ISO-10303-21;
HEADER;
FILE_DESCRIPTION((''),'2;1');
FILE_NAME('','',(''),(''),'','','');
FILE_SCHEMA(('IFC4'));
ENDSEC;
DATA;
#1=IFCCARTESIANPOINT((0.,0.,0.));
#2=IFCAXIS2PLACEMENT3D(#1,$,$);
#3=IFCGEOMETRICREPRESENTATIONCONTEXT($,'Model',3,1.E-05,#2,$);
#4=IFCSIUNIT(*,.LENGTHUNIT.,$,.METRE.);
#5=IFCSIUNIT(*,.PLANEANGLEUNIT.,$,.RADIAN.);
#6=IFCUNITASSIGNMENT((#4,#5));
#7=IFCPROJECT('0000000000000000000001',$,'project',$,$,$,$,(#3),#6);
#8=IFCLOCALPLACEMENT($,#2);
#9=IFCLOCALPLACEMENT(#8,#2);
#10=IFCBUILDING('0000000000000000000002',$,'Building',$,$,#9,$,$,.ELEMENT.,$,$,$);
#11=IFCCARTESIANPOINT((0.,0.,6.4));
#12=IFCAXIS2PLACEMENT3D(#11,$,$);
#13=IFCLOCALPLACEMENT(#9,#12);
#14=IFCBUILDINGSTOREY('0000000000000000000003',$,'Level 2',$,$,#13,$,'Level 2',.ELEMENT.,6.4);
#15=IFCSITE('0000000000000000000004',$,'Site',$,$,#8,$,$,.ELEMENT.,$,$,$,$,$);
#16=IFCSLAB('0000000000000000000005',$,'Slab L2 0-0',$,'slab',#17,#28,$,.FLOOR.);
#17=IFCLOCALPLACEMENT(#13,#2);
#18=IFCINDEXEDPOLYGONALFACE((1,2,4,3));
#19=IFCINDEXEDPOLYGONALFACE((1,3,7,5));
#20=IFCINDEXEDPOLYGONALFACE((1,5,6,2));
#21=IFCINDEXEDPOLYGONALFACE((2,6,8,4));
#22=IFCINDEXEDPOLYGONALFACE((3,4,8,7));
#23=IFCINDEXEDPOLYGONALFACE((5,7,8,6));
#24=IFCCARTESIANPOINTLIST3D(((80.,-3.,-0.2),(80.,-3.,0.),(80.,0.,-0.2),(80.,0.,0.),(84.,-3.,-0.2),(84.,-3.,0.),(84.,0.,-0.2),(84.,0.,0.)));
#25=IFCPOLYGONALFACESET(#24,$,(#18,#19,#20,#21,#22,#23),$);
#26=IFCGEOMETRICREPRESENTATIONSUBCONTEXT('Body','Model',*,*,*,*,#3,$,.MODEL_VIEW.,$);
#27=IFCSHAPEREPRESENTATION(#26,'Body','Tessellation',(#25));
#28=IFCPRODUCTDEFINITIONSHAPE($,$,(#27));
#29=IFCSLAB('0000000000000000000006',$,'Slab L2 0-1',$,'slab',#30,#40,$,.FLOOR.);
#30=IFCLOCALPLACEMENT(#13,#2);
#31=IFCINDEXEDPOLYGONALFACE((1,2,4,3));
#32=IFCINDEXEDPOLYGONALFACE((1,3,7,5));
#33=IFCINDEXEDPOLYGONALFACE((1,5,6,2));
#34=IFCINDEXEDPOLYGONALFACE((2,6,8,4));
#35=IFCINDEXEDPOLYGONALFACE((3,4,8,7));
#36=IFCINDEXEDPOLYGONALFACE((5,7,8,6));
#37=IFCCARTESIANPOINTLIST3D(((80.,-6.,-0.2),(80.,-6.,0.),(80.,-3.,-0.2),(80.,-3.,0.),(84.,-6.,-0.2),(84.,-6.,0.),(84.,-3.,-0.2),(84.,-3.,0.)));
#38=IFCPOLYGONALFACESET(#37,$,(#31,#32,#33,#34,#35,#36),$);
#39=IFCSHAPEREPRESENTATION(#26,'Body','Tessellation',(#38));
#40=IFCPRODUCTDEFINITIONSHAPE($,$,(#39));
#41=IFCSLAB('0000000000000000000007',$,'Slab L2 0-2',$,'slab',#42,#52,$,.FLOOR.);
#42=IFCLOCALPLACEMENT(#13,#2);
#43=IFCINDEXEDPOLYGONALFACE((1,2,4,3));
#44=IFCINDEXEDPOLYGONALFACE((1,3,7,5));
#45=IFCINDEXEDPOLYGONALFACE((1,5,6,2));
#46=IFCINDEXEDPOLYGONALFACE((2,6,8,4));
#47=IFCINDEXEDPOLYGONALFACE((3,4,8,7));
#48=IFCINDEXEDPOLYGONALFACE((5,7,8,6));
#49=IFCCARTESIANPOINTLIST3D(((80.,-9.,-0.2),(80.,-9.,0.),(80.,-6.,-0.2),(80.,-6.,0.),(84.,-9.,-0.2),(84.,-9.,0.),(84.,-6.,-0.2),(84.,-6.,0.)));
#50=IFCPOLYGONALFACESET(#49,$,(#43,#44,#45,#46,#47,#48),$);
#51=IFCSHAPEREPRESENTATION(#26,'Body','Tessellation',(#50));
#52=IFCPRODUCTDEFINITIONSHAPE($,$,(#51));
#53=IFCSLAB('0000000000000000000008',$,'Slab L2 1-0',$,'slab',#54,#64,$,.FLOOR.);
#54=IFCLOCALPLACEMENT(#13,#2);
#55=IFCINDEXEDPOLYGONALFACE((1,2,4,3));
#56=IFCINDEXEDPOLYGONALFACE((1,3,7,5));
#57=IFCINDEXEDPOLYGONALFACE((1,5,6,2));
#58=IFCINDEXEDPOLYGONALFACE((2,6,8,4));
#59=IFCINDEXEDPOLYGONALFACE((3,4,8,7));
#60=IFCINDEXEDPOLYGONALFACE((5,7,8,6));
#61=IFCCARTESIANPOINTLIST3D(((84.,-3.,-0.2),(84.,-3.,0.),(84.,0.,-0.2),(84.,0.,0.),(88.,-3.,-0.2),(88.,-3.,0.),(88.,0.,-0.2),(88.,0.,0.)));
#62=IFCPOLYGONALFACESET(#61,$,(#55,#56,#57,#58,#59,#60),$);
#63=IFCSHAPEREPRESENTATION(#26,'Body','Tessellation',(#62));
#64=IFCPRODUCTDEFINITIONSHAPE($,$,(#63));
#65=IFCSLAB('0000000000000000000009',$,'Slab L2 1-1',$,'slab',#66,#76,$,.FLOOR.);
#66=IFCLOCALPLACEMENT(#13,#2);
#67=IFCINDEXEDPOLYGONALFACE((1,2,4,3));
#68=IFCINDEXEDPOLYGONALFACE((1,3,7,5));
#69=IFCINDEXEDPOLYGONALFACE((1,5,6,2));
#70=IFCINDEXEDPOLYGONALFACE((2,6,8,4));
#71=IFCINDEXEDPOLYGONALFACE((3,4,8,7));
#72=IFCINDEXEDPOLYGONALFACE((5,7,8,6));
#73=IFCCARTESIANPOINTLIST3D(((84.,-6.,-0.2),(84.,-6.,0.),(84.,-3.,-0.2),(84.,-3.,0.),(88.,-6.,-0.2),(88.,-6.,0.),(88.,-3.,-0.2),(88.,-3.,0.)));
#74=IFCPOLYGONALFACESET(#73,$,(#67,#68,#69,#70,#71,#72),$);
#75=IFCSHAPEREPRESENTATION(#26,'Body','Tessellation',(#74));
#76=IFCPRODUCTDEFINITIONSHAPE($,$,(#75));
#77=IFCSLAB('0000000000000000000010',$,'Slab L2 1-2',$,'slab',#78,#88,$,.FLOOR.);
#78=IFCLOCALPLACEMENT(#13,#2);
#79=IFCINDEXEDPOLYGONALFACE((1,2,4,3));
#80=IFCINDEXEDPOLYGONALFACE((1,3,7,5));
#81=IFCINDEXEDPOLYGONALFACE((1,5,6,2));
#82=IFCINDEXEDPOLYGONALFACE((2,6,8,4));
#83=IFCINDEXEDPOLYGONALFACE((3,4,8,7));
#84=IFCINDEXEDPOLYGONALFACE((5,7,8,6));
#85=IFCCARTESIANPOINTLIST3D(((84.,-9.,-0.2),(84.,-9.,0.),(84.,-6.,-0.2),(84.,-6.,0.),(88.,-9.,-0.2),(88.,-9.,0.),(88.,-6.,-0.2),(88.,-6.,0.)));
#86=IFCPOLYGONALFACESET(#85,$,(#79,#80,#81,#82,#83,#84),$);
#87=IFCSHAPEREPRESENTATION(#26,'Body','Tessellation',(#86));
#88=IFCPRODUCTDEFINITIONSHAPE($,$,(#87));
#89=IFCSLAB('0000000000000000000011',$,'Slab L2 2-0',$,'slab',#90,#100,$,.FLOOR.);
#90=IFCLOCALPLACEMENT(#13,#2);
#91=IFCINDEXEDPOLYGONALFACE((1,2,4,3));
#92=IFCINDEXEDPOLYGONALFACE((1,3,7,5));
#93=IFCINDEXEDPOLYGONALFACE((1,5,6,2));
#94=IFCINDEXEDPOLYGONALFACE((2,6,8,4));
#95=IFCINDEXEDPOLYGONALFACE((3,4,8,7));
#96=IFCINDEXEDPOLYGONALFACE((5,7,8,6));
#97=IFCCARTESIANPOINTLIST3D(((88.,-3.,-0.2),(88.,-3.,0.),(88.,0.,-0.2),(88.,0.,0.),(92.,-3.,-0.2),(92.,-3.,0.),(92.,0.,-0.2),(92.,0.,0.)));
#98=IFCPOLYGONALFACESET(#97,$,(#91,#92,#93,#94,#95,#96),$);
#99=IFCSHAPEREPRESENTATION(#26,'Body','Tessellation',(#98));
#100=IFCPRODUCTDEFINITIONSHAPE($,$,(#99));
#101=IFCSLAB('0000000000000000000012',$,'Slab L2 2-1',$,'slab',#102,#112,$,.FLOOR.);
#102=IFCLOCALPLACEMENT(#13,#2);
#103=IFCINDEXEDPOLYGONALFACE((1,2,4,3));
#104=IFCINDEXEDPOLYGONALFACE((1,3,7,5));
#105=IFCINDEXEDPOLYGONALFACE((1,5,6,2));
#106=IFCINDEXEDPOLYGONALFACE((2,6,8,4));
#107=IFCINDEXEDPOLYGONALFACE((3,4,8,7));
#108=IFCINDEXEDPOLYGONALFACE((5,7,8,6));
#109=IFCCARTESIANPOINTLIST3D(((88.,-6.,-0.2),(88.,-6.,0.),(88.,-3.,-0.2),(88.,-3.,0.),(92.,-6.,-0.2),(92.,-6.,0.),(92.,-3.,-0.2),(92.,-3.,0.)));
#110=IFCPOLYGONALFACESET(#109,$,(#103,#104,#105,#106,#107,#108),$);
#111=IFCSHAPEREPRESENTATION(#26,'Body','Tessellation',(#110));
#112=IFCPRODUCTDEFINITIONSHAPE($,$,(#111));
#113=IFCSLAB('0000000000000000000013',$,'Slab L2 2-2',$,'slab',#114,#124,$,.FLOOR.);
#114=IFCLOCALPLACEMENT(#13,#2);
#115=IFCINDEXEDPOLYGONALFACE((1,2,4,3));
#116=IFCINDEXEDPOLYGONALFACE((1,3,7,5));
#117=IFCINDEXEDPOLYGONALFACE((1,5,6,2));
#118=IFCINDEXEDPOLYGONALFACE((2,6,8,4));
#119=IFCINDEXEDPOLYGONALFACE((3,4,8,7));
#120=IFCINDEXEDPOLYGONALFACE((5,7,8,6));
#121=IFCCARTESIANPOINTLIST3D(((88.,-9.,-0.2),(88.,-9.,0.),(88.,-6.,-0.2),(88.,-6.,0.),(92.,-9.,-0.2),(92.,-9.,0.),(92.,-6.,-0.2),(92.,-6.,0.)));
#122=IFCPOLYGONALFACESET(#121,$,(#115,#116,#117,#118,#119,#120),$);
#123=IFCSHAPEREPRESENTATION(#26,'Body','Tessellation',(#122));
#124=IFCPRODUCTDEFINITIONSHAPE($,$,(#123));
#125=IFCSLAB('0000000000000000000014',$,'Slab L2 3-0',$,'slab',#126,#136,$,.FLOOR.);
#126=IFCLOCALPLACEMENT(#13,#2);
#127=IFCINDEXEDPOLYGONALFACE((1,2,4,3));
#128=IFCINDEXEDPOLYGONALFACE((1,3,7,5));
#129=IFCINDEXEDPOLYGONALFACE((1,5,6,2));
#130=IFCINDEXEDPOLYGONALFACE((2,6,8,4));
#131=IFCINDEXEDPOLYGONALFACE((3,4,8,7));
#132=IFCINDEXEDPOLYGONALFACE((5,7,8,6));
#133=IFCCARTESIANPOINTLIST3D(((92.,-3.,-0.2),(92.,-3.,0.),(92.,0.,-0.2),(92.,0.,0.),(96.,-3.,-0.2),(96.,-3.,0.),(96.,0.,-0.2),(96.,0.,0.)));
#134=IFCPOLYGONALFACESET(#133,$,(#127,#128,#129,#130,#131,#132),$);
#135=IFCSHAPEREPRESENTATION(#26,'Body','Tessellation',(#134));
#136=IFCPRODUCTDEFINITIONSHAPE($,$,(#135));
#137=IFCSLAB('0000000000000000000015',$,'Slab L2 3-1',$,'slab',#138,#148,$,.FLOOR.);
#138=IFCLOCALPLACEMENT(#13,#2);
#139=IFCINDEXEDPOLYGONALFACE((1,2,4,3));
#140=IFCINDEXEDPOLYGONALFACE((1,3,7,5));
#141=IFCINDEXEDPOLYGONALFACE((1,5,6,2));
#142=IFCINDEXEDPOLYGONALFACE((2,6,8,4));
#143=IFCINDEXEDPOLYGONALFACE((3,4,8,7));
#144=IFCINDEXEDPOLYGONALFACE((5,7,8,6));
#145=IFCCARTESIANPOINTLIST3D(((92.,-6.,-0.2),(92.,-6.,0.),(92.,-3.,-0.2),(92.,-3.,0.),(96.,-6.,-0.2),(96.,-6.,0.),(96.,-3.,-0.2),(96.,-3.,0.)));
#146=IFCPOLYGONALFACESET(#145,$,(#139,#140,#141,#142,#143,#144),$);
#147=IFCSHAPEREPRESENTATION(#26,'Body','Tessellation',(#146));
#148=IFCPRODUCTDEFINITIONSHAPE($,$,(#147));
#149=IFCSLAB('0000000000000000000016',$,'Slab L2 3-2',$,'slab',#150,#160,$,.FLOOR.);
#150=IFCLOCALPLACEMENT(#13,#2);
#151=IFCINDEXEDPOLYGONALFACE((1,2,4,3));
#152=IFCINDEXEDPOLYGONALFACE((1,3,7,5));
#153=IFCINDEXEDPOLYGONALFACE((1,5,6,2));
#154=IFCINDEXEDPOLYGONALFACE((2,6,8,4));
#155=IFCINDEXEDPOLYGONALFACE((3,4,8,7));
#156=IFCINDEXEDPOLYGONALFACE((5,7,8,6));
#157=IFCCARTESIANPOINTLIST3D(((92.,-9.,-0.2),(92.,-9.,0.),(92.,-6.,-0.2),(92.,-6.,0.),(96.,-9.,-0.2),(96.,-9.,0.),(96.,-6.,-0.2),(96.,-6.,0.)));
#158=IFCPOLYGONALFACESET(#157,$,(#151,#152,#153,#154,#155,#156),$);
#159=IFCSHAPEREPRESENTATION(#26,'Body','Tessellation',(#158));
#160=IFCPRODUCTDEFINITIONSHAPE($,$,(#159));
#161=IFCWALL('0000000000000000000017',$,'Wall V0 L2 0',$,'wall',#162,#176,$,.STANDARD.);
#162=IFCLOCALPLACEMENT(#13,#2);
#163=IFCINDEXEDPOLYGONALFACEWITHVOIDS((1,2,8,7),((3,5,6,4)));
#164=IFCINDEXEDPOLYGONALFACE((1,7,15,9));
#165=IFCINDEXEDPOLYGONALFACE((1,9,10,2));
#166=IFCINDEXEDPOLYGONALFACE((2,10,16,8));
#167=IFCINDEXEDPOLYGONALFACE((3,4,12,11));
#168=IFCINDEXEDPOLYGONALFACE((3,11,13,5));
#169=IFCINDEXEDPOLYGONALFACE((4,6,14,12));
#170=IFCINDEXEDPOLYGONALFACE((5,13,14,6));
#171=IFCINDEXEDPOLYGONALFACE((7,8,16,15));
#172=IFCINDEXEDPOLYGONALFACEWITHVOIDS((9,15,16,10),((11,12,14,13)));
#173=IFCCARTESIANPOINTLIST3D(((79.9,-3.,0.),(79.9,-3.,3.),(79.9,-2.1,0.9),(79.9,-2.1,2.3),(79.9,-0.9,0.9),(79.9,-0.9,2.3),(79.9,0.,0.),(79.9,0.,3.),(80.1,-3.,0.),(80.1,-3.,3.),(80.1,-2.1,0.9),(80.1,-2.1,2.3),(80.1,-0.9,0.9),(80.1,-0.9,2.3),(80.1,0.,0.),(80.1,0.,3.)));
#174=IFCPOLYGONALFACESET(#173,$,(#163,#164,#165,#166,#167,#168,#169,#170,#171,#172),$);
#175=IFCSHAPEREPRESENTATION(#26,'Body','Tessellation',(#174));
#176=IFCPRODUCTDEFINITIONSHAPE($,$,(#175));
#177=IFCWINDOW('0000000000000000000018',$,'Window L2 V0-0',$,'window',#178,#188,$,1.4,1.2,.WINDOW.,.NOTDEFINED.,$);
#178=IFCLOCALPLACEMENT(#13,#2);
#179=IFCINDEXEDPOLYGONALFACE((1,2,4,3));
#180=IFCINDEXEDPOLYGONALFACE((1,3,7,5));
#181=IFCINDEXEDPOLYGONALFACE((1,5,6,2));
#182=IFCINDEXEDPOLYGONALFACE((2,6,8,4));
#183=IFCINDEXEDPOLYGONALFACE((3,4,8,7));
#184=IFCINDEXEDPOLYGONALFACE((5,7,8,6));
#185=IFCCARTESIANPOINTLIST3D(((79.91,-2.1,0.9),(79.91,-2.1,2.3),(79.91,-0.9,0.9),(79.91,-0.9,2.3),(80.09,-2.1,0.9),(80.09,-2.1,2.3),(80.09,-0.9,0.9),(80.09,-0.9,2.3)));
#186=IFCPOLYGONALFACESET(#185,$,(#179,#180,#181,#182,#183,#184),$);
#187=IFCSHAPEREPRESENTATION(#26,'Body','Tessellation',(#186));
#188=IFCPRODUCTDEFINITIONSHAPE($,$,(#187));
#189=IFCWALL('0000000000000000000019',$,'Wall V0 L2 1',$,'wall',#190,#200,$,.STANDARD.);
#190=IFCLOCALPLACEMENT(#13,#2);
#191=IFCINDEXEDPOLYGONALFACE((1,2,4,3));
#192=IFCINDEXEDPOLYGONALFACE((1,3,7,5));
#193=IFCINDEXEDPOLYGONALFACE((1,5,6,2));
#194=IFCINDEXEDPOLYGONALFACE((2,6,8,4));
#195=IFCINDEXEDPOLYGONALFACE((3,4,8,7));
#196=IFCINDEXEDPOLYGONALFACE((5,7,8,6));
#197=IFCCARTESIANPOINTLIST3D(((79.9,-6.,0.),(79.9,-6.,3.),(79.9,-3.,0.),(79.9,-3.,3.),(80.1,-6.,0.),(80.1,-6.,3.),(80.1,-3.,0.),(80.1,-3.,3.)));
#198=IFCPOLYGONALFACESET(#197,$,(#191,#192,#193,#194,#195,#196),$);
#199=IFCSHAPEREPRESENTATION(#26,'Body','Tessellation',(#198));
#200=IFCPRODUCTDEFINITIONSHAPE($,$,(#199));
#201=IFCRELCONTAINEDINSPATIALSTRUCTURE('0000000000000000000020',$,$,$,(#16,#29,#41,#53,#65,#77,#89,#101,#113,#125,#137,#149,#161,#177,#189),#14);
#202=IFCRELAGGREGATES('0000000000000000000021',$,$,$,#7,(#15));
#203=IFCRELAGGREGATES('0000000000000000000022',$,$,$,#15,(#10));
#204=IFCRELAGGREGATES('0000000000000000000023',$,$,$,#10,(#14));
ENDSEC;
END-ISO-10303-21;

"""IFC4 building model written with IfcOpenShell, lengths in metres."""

from ifc_helpers import new_model, si_unit, frame, frame_2d, origin, origin_2d, place, context, subcontext, project, spatial, polyline, rectangle, outline, extrude, element, fill, save


model = new_model("IFC4")

# Units and contexts
model_context = context("Model", 3, precision=1e-05, world=origin())
body_context = subcontext(model_context, "Body", "Model", "MODEL_VIEW")
ifc_project = project(units=[si_unit("LENGTHUNIT", "METRE"), si_unit("PLANEANGLEUNIT", "RADIAN")], contexts=[model_context])

# Site, building, storey
site_placement = place(None, origin())
site = spatial("IfcSite", under=ifc_project, at=site_placement, Name="Site", CompositionType="ELEMENT")
building_placement = place(site_placement, origin())
building = spatial("IfcBuilding", under=site, at=building_placement, Name="Building", CompositionType="ELEMENT")
storey_placement = place(building_placement, frame((0.0, 0.0, 6.4)))
storey = spatial("IfcBuildingStorey", under=building, at=storey_placement, Name="Level 2", LongName="Level 2", CompositionType="ELEMENT", Elevation=6.4)

# Slabs
slab_1_placement = place(storey_placement, frame((0.0, 0.0, -0.2)))
element("IfcSlab", 1, at=slab_1_placement, inside=storey, Name="Slab L2 0-0", ObjectType="slab", PredefinedType="FLOOR", context=body_context, shape_type="SweptSolid", body=[
    extrude(outline(polyline([(80.0, -3.0), (84.0, -3.0), (84.0, 0.0), (80.0, 0.0), (80.0, -3.0)])), origin(), (0.0, 0.0, 1.0), 0.2),
])
slab_2_placement = place(storey_placement, frame((0.0, 0.0, -0.2)))
element("IfcSlab", 2, at=slab_2_placement, inside=storey, Name="Slab L2 0-1", ObjectType="slab", PredefinedType="FLOOR", context=body_context, shape_type="SweptSolid", body=[
    extrude(outline(polyline([(80.0, -6.0), (84.0, -6.0), (84.0, -3.0), (80.0, -3.0), (80.0, -6.0)])), origin(), (0.0, 0.0, 1.0), 0.2),
])
slab_3_placement = place(storey_placement, frame((0.0, 0.0, -0.2)))
element("IfcSlab", 3, at=slab_3_placement, inside=storey, Name="Slab L2 0-2", ObjectType="slab", PredefinedType="FLOOR", context=body_context, shape_type="SweptSolid", body=[
    extrude(outline(polyline([(80.0, -9.0), (84.0, -9.0), (84.0, -6.0), (80.0, -6.0), (80.0, -9.0)])), origin(), (0.0, 0.0, 1.0), 0.2),
])
slab_4_placement = place(storey_placement, frame((0.0, 0.0, -0.2)))
element("IfcSlab", 4, at=slab_4_placement, inside=storey, Name="Slab L2 1-0", ObjectType="slab", PredefinedType="FLOOR", context=body_context, shape_type="SweptSolid", body=[
    extrude(outline(polyline([(84.0, -3.0), (88.0, -3.0), (88.0, 0.0), (84.0, 0.0), (84.0, -3.0)])), origin(), (0.0, 0.0, 1.0), 0.2),
])
slab_5_placement = place(storey_placement, frame((0.0, 0.0, -0.2)))
element("IfcSlab", 5, at=slab_5_placement, inside=storey, Name="Slab L2 1-1", ObjectType="slab", PredefinedType="FLOOR", context=body_context, shape_type="SweptSolid", body=[
    extrude(outline(polyline([(84.0, -6.0), (88.0, -6.0), (88.0, -3.0), (84.0, -3.0), (84.0, -6.0)])), origin(), (0.0, 0.0, 1.0), 0.2),
])
slab_6_placement = place(storey_placement, frame((0.0, 0.0, -0.2)))
element("IfcSlab", 6, at=slab_6_placement, inside=storey, Name="Slab L2 1-2", ObjectType="slab", PredefinedType="FLOOR", context=body_context, shape_type="SweptSolid", body=[
    extrude(outline(polyline([(84.0, -9.0), (88.0, -9.0), (88.0, -6.0), (84.0, -6.0), (84.0, -9.0)])), origin(), (0.0, 0.0, 1.0), 0.2),
])
slab_7_placement = place(storey_placement, frame((0.0, 0.0, -0.2)))
element("IfcSlab", 7, at=slab_7_placement, inside=storey, Name="Slab L2 2-0", ObjectType="slab", PredefinedType="FLOOR", context=body_context, shape_type="SweptSolid", body=[
    extrude(outline(polyline([(88.0, -3.0), (92.0, -3.0), (92.0, 0.0), (88.0, 0.0), (88.0, -3.0)])), origin(), (0.0, 0.0, 1.0), 0.2),
])
slab_8_placement = place(storey_placement, frame((0.0, 0.0, -0.2)))
element("IfcSlab", 8, at=slab_8_placement, inside=storey, Name="Slab L2 2-1", ObjectType="slab", PredefinedType="FLOOR", context=body_context, shape_type="SweptSolid", body=[
    extrude(outline(polyline([(88.0, -6.0), (92.0, -6.0), (92.0, -3.0), (88.0, -3.0), (88.0, -6.0)])), origin(), (0.0, 0.0, 1.0), 0.2),
])
slab_9_placement = place(storey_placement, frame((0.0, 0.0, -0.2)))
element("IfcSlab", 9, at=slab_9_placement, inside=storey, Name="Slab L2 2-2", ObjectType="slab", PredefinedType="FLOOR", context=body_context, shape_type="SweptSolid", body=[
    extrude(outline(polyline([(88.0, -9.0), (92.0, -9.0), (92.0, -6.0), (88.0, -6.0), (88.0, -9.0)])), origin(), (0.0, 0.0, 1.0), 0.2),
])
slab_10_placement = place(storey_placement, frame((0.0, 0.0, -0.2)))
element("IfcSlab", 10, at=slab_10_placement, inside=storey, Name="Slab L2 3-0", ObjectType="slab", PredefinedType="FLOOR", context=body_context, shape_type="SweptSolid", body=[
    extrude(outline(polyline([(92.0, -3.0), (96.0, -3.0), (96.0, 0.0), (92.0, 0.0), (92.0, -3.0)])), origin(), (0.0, 0.0, 1.0), 0.2),
])
slab_11_placement = place(storey_placement, frame((0.0, 0.0, -0.2)))
element("IfcSlab", 11, at=slab_11_placement, inside=storey, Name="Slab L2 3-1", ObjectType="slab", PredefinedType="FLOOR", context=body_context, shape_type="SweptSolid", body=[
    extrude(outline(polyline([(92.0, -6.0), (96.0, -6.0), (96.0, -3.0), (92.0, -3.0), (92.0, -6.0)])), origin(), (0.0, 0.0, 1.0), 0.2),
])
slab_12_placement = place(storey_placement, frame((0.0, 0.0, -0.2)))
element("IfcSlab", 12, at=slab_12_placement, inside=storey, Name="Slab L2 3-2", ObjectType="slab", PredefinedType="FLOOR", context=body_context, shape_type="SweptSolid", body=[
    extrude(outline(polyline([(92.0, -9.0), (96.0, -9.0), (96.0, -6.0), (92.0, -6.0), (92.0, -9.0)])), origin(), (0.0, 0.0, 1.0), 0.2),
])

# Wall, opening, window
wall_1_placement = place(storey_placement, frame((80.0, 0.0, 0.0), z_axis=(0.0, 0.0, 1.0), x_axis=(0.0, -1.0, 0.0)))
wall_1 = element("IfcWall", 13, at=wall_1_placement, inside=storey, Name="Wall V0 L2 0", ObjectType="wall", PredefinedType="STANDARD", context=body_context, shape_type="SweptSolid", body=[
    extrude(rectangle(XDim=3.0, YDim=0.2, at=frame_2d((1.5, 0.0))), origin(), (0.0, 0.0, 1.0), 3.0),
])
opening_1_placement = place(storey_placement, frame((80.0, -1.5, 0.9), z_axis=(0.0, 0.0, 1.0), x_axis=(0.0, -1.0, 0.0)))
opening_1 = element("IfcOpeningElement", 14, at=opening_1_placement, cuts=wall_1, ObjectType="Opening", PredefinedType="OPENING", context=body_context, shape_type="SweptSolid", body=[
    extrude(rectangle(XDim=1.2, YDim=0.22, at=origin_2d()), origin(), (0.0, 0.0, 1.0), 1.4),
])
window_1_placement = place(storey_placement, frame((80.0, -1.5, 0.9), z_axis=(0.0, 0.0, 1.0), x_axis=(0.0, -1.0, 0.0)))
window_1 = element("IfcWindow", 15, at=window_1_placement, inside=storey, Name="Window L2 V0-0", ObjectType="window", OverallHeight=1.4, OverallWidth=1.2, PartitioningType="NOTDEFINED", PredefinedType="WINDOW", context=body_context, shape_type="SweptSolid", body=[
    extrude(rectangle(XDim=1.2, YDim=0.18, at=origin_2d()), origin(), (0.0, 0.0, 1.0), 1.4),
])
fill(opening_1, window_1)

# Wall
wall_2_placement = place(storey_placement, frame((80.0, -3.0, 0.0), z_axis=(0.0, 0.0, 1.0), x_axis=(0.0, -1.0, 0.0)))
element("IfcWall", 16, at=wall_2_placement, inside=storey, Name="Wall V0 L2 1", ObjectType="wall", PredefinedType="STANDARD", context=body_context, shape_type="SweptSolid", body=[
    extrude(rectangle(XDim=3.0, YDim=0.2, at=frame_2d((1.5, 0.0))), origin(), (0.0, 0.0, 1.0), 3.0),
])

save(model, "model.ifc")
